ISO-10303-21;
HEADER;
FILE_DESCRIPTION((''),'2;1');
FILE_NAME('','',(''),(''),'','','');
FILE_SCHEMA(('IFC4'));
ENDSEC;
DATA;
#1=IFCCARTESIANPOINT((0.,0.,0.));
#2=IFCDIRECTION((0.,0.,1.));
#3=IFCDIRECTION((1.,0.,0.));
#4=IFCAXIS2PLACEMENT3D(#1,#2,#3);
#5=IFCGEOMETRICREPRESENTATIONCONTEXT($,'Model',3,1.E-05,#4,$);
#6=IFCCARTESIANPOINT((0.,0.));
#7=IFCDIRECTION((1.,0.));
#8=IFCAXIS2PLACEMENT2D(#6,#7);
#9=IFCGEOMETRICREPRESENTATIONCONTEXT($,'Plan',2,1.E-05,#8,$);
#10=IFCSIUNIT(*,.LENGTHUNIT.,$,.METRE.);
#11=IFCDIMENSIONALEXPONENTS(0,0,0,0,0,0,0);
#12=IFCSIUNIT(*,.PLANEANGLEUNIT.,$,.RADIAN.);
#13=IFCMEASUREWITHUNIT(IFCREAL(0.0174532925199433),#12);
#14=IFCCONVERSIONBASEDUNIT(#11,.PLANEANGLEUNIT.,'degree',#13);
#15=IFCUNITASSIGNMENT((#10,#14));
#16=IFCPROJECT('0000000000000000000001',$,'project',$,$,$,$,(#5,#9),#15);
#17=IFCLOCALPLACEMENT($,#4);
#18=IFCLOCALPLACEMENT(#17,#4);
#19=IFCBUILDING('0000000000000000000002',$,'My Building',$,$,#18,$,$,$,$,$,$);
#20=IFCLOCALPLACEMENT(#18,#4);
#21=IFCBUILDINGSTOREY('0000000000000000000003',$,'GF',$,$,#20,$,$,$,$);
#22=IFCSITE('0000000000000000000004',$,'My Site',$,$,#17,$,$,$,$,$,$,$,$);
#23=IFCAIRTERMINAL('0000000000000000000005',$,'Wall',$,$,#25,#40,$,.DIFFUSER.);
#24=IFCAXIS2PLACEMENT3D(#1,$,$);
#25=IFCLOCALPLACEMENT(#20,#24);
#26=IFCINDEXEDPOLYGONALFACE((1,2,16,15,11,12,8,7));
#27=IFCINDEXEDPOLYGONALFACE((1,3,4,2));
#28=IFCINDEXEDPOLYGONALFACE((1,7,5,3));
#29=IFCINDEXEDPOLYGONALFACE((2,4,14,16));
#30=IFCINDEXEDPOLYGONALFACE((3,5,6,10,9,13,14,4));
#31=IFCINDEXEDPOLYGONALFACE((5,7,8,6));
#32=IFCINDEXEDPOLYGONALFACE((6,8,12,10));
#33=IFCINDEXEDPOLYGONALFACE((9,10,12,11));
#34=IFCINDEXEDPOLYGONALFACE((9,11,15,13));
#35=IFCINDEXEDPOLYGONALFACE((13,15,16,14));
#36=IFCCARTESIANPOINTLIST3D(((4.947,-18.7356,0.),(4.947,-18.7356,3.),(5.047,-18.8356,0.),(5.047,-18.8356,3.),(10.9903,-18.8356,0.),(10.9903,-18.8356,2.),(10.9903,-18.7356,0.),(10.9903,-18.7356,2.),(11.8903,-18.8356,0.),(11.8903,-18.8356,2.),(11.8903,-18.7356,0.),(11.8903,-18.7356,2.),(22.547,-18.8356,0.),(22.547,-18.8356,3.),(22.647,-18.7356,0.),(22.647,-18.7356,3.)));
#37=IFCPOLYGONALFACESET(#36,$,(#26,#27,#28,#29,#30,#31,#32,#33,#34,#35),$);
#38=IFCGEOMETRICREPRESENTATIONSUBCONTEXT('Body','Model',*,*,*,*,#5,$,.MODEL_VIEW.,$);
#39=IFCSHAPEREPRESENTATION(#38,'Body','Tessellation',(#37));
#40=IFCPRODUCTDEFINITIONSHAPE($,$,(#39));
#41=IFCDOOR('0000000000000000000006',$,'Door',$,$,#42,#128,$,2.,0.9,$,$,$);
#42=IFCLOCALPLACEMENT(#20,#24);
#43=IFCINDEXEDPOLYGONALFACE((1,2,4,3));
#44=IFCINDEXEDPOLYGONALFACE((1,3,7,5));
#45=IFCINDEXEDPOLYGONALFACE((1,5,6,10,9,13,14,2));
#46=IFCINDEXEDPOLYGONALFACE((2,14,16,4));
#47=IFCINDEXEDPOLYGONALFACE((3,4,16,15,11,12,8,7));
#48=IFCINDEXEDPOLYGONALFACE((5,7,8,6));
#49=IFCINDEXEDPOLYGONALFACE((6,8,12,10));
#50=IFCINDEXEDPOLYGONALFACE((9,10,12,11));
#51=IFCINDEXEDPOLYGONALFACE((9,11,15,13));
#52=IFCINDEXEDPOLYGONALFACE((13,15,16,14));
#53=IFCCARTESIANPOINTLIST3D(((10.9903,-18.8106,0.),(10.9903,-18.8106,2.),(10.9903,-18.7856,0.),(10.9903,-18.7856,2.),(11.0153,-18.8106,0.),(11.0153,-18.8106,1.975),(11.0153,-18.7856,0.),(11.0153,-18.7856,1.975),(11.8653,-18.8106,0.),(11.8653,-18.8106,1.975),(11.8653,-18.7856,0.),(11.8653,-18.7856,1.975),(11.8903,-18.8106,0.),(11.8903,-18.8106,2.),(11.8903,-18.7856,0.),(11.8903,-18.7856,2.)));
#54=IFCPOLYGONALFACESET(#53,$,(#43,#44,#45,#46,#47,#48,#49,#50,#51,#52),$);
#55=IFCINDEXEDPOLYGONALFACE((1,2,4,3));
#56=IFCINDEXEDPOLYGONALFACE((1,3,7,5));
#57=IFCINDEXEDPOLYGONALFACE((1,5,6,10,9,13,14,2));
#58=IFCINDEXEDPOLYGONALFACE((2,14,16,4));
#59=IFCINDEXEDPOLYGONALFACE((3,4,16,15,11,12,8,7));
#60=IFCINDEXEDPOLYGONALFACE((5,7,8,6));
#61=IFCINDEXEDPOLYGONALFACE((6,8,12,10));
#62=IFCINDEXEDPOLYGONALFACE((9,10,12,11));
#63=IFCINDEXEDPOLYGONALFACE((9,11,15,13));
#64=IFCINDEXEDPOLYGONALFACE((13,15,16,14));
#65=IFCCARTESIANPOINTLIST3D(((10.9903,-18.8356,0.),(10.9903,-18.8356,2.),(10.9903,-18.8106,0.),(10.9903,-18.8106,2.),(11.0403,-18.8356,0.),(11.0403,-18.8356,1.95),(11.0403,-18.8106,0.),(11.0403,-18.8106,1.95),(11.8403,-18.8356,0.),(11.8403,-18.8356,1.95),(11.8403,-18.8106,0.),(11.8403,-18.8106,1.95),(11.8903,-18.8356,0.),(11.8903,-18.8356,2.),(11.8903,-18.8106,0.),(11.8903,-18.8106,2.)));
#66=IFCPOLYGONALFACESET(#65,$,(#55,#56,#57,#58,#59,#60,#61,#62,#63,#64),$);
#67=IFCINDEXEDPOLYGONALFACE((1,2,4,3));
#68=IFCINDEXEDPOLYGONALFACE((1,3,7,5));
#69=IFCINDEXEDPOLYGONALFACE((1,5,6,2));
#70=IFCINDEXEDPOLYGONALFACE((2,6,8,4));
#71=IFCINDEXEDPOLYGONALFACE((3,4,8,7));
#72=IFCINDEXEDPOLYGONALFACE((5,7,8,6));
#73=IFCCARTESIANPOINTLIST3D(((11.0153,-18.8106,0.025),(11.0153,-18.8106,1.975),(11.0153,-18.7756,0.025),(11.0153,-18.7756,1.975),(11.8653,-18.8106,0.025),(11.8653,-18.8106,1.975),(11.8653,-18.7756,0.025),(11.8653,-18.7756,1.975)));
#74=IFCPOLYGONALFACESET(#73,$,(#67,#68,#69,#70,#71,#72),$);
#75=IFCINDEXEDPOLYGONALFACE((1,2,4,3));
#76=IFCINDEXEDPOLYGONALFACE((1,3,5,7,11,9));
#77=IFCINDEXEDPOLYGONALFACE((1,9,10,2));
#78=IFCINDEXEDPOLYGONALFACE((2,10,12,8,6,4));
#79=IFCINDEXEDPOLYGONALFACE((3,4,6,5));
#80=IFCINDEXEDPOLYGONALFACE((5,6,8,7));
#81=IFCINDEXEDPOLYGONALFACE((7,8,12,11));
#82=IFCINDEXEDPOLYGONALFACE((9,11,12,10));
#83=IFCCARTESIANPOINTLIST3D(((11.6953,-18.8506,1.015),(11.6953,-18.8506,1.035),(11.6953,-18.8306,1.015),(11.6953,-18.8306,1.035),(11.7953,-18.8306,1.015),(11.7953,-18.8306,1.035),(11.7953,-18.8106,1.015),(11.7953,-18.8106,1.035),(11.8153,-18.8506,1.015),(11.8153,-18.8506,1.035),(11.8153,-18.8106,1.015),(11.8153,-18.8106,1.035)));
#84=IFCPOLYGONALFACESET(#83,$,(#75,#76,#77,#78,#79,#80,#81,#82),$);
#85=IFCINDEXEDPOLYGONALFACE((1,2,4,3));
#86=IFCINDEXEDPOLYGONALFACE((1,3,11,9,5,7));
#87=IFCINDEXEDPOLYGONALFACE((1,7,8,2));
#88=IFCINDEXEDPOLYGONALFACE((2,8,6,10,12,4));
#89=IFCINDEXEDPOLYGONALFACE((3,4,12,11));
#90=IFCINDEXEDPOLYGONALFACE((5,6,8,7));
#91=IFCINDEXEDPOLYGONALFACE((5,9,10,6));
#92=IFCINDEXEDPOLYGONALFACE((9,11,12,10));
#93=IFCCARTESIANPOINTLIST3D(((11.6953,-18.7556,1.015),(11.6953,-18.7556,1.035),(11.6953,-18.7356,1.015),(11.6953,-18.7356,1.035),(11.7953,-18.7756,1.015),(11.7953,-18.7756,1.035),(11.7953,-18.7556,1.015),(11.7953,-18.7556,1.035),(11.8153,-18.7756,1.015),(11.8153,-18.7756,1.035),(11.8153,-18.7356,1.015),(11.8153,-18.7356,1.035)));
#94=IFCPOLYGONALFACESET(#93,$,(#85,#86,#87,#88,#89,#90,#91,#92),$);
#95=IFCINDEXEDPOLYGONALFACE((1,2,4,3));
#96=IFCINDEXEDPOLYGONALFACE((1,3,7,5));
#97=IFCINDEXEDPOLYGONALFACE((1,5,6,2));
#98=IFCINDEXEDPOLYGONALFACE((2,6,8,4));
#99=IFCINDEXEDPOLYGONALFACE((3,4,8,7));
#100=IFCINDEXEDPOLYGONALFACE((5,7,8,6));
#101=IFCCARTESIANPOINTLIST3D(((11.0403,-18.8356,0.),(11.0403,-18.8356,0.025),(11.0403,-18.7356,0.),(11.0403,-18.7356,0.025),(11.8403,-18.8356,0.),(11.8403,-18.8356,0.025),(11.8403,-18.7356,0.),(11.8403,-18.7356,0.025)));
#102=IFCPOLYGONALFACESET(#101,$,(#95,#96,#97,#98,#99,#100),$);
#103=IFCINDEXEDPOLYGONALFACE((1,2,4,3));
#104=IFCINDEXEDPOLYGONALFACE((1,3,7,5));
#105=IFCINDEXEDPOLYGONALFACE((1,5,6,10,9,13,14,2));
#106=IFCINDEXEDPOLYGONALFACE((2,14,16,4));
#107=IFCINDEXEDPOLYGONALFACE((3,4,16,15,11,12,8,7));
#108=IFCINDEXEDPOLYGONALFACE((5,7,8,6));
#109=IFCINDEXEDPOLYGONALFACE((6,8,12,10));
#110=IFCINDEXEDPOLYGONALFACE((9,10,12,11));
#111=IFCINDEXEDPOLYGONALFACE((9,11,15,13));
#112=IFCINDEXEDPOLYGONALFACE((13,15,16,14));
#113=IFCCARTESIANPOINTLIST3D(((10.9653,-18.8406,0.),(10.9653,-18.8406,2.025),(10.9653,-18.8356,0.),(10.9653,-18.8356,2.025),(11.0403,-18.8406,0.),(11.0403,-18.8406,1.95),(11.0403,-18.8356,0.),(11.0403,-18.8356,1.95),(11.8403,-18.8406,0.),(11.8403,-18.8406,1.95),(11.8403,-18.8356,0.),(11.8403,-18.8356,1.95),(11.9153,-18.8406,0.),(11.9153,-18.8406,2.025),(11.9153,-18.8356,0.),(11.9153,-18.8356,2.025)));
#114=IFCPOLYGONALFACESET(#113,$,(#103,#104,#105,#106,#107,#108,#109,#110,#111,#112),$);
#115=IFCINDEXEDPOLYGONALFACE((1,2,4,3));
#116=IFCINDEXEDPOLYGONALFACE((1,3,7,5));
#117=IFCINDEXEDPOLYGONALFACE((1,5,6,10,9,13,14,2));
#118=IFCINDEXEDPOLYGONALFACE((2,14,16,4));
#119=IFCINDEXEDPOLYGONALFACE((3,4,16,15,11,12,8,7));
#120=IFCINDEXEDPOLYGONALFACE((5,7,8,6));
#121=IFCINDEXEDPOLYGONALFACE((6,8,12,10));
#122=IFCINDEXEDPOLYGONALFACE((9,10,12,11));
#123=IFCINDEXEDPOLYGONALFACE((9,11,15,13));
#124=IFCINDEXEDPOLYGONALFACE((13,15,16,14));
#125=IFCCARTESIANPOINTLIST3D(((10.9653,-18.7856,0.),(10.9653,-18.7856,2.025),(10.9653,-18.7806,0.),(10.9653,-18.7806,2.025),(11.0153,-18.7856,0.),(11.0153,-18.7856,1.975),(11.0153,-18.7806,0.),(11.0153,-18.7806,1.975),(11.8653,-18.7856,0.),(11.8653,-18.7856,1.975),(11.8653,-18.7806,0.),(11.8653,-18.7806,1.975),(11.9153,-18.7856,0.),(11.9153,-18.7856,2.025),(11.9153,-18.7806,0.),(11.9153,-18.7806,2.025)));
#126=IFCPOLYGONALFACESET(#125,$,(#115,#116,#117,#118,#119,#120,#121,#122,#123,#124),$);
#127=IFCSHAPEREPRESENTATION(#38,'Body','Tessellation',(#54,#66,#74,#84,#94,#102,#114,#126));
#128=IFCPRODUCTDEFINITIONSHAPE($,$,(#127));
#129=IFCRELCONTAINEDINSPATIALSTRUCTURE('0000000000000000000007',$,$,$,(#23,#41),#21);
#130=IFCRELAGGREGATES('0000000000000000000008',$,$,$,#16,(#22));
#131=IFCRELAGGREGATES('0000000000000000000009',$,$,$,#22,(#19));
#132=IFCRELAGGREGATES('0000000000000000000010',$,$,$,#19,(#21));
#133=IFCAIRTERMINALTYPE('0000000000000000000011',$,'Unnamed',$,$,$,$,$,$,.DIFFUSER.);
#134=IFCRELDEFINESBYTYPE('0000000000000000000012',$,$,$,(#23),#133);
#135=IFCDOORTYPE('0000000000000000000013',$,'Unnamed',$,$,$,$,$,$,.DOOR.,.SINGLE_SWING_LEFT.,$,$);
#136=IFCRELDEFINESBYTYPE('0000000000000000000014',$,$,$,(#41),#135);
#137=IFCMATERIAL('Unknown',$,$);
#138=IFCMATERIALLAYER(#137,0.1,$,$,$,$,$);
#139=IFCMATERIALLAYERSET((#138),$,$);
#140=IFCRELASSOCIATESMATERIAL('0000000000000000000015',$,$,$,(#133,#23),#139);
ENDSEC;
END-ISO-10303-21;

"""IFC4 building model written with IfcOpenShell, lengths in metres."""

from ifc_helpers import new_model, entity, si_unit, converted_unit, frame, origin_with_axes, origin_2d_with_axis, place, context, subcontext, project, spatial, line, indexed_curve, outline, extrude, shape, source, transform, mapped, material, layer, layer_set, layer_usage, type_object, type_shapes, element, fill, save


model = new_model("IFC4")

# Units and contexts
model_context = context("Model", 3, precision=1e-05, world=origin_with_axes())
plan_context = context("Plan", 2, precision=1e-05, world=origin_2d_with_axis())
body_context_1 = subcontext(model_context, "Body", "Model", "MODEL_VIEW")
body_context_2 = subcontext(plan_context, "Body", "Plan", "PLAN_VIEW")
ifc_project = project(units=[si_unit("LENGTHUNIT", "METRE"), converted_unit("PLANEANGLEUNIT", "degree", entity("IfcReal", 0.0174532925199433), si_unit("PLANEANGLEUNIT", "RADIAN"), dimensions=[0, 0, 0, 0, 0, 0, 0])], contexts=[model_context, plan_context])

# Site, building, storey
site_placement = place(None, origin_with_axes())
site = spatial("IfcSite", under=ifc_project, at=site_placement, Name="My Site")
building_placement = place(site_placement, origin_with_axes())
building = spatial("IfcBuilding", under=site, at=building_placement, Name="My Building")
storey_placement = place(building_placement, origin_with_axes())
storey = spatial("IfcBuildingStorey", under=building, at=storey_placement, Name="GF")

# Shared definitions
ifc_material = material(Name="Unknown")
ifc_layer = layer(ifc_material, 0.1)
ifc_layer_set = layer_set([ifc_layer])
air_terminal_type = type_object("IfcAirTerminalType", Name="Unnamed", PredefinedType="DIFFUSER", material=ifc_layer_set)

# Shared definitions
shared_shape_1 = source(origin_with_axes(), body_context_1, "Body", "SweptSolid", [
    extrude(outline(indexed_curve([(0.0, 0.0), (0.9, 0.0), (0.9, 2.0), (0.0, 2.0)], segments=[line(1, 2, 3, 4, 1)])), frame((0.0, -0.6, 0.0), z_axis=(0.0, -1.0, 0.0), x_axis=(1.0, 0.0, 0.0)), (0.0, 0.0, -1.0), 1.2),
])
door_type = type_object("IfcDoorType", Name="Unnamed", OperationType="SINGLE_SWING_LEFT", PredefinedType="DOOR")
shared_shape_2 = source(origin_with_axes(), body_context_1, "Body", "SweptSolid", [
    extrude(outline(indexed_curve([(0.0, 0.0), (0.0, 2.0), (0.9, 2.0), (0.9, 0.0), (0.875, 0.0), (0.875, 1.975), (0.025, 1.975), (0.025, 0.0)], segments=[line(1, 2, 3, 4, 5, 6, 7, 8, 1)])), frame((0.0, 0.025, 0.0), z_axis=(0.0, -1.0, 0.0), x_axis=(1.0, 0.0, 0.0)), (0.0, 0.0, -1.0), 0.025),
    extrude(outline(indexed_curve([(0.0, 0.0), (0.0, 2.0), (0.9, 2.0), (0.9, 0.0), (0.85, 0.0), (0.85, 1.95), (0.05, 1.95), (0.05, 0.0)], segments=[line(1, 2, 3, 4, 5, 6, 7, 8, 1)])), frame((0.0, 0.0, 0.0), z_axis=(0.0, -1.0, 0.0), x_axis=(1.0, 0.0, 0.0)), (0.0, 0.0, -1.0), 0.025),
    extrude(outline(indexed_curve([(0.0, 0.0), (0.85, 0.0), (0.85, 0.035), (0.0, 0.035)], segments=[line(1, 2, 3, 4, 1)])), frame((0.025, 0.025, 0.025), z_axis=(0.0, 0.0, 1.0), x_axis=(1.0, 0.0, 0.0)), (0.0, 0.0, 1.0), 1.95),
    extrude(outline(indexed_curve([(0.0, 0.0), (0.0, -0.04), (-0.12, -0.04), (-0.12, -0.02), (-0.02, -0.02), (-0.02, 0.0)], segments=[line(1, 2, 3, 4, 5, 6, 1)])), frame((0.825, 0.025, 1.015), z_axis=(0.0, 0.0, 1.0), x_axis=(1.0, 0.0, 0.0)), (0.0, 0.0, 1.0), 0.02),
    extrude(outline(indexed_curve([(0.0, 0.0), (0.0, 0.04), (-0.12, 0.04), (-0.12, 0.02), (-0.02, 0.02), (-0.02, 0.0)], segments=[line(1, 2, 3, 4, 5, 6, 1)])), frame((0.825, 0.06, 1.015), z_axis=(0.0, 0.0, 1.0), x_axis=(1.0, 0.0, 0.0)), (0.0, 0.0, 1.0), 0.02),
    extrude(outline(indexed_curve([(0.0, 0.0), (0.8, 0.0), (0.8, 0.1), (0.0, 0.1)], segments=[line(1, 2, 3, 4, 1)])), frame((0.05, 0.0, 0.0), z_axis=(0.0, 0.0, 1.0), x_axis=(1.0, 0.0, 0.0)), (0.0, 0.0, 1.0), 0.025),
    extrude(outline(indexed_curve([(0.0, 0.0), (0.0, 2.025), (0.95, 2.025), (0.95, 0.0), (0.875, 0.0), (0.875, 1.95), (0.075, 1.95), (0.075, 0.0)], segments=[line(1, 2, 3, 4, 5, 6, 7, 8, 1)])), frame((-0.025, -0.005, 0.0), z_axis=(0.0, -1.0, 0.0), x_axis=(1.0, 0.0, 0.0)), (0.0, 0.0, -1.0), 0.005),
    extrude(outline(indexed_curve([(0.0, 0.0), (0.0, 2.025), (0.95, 2.025), (0.95, 0.0), (0.9, 0.0), (0.9, 1.975), (0.05, 1.975), (0.05, 0.0)], segments=[line(1, 2, 3, 4, 5, 6, 7, 8, 1)])), frame((-0.025, 0.05, 0.0), z_axis=(0.0, -1.0, 0.0), x_axis=(1.0, 0.0, 0.0)), (0.0, 0.0, -1.0), 0.005),
])
shared_shape_3 = source(origin_with_axes(), body_context_2, "Body", "Curve2D", [
    entity("IfcIndexedPolyCurve", entity("IfcCartesianPointList2D", [[0.0, 0.0], [0.0, 0.05], [0.025, 0.05], [0.025, 0.025], [0.05, 0.025], [0.05, 0.0]]), [entity("IfcLineIndex", [1, 2, 3, 4, 5, 6, 1])]),
    entity("IfcIndexedPolyCurve", entity("IfcCartesianPointList2D", [[0.9, 0.0], [0.9, 0.05], [0.875, 0.05], [0.875, 0.025], [0.85, 0.025], [0.85, 0.0]]), [entity("IfcLineIndex", [1, 2, 3, 4, 5, 6, 1])]),
    entity("IfcTrimmedCurve", entity("IfcEllipse", entity("IfcAxis2Placement2D", entity("IfcCartesianPoint", [0.06, 0.05]), entity("IfcDirection", [1.0, 0.0])), 0.815, 0.85), [entity("IfcCartesianPoint", [0.875, 0.05])], [entity("IfcCartesianPoint", [0.06, 0.9])], True, "CARTESIAN"),
    entity("IfcIndexedPolyCurve", entity("IfcCartesianPointList2D", [[0.025, 0.05], [0.06, 0.05], [0.06, 0.9], [0.025, 0.9]]), [entity("IfcLineIndex", [1, 2, 3, 4, 1])]),
])
type_shapes(door_type, [shared_shape_2, shared_shape_3])

# Air terminal, opening, door
ifc_layer_usage_1 = layer_usage(ifc_layer_set, "AXIS2", "POSITIVE", 0.0)
air_terminal_1_placement = place(storey_placement, frame((5.047, -18.8356, 0.0), z_axis=(0.0, 0.0, 1.0), x_axis=(1.0, 0.0, 0.0)))
air_terminal_1 = element("IfcAirTerminal", 1, at=air_terminal_1_placement, inside=storey, type_object=air_terminal_type, material=ifc_layer_usage_1, Name="Wall", PredefinedType="DIFFUSER", context=body_context_1, shape_type="SweptSolid", body=[
    extrude(outline(indexed_curve([(0.0, 0.0), (-0.1, 0.1), (17.6, 0.1), (17.5, 0.0)], segments=[line(1, 2, 3, 4, 1)])), origin_with_axes(), (0.0, 0.0, 1.0), 3.0),
])
opening_1_placement = place(air_terminal_1_placement, frame((5.9433, 0.0, 0.0), z_axis=(0.0, 0.0, 1.0), x_axis=(1.0, 0.0, 0.0)))
opening_1 = element("IfcOpeningElement", 2, at=opening_1_placement, cuts=air_terminal_1, PredefinedType="OPENING", context=body_context_1, shape_type="MappedRepresentation", body=[
    mapped(shared_shape_1, transform((0.0, 0.0, 0.0), x_axis=(1.0, 0.0, 0.0), y_axis=(0.0, 1.0, 0.0), z_axis=(0.0, 0.0, 1.0), scale=1.0)),
])
door_1_placement = place(opening_1_placement, origin_with_axes())
door_1 = element("IfcDoor", 3, at=door_1_placement, inside=storey, type_object=door_type, Name="Door", OverallHeight=2.0, OverallWidth=0.9, shapes=[
    shape(body_context_1, "Body", "MappedRepresentation", [mapped(shared_shape_2, transform((0.0, 0.0, 0.0), x_axis=(1.0, 0.0, 0.0), y_axis=(0.0, 1.0, 0.0), z_axis=(0.0, 0.0, 1.0), scale=1.0))]),
    shape(body_context_2, "Body", "MappedRepresentation", [mapped(shared_shape_3, transform((0.0, 0.0, 0.0), x_axis=(1.0, 0.0, 0.0), y_axis=(0.0, 1.0, 0.0), z_axis=(0.0, 0.0, 1.0), scale=1.0))]),
])
fill(opening_1, door_1)

save(model, "model.ifc")
